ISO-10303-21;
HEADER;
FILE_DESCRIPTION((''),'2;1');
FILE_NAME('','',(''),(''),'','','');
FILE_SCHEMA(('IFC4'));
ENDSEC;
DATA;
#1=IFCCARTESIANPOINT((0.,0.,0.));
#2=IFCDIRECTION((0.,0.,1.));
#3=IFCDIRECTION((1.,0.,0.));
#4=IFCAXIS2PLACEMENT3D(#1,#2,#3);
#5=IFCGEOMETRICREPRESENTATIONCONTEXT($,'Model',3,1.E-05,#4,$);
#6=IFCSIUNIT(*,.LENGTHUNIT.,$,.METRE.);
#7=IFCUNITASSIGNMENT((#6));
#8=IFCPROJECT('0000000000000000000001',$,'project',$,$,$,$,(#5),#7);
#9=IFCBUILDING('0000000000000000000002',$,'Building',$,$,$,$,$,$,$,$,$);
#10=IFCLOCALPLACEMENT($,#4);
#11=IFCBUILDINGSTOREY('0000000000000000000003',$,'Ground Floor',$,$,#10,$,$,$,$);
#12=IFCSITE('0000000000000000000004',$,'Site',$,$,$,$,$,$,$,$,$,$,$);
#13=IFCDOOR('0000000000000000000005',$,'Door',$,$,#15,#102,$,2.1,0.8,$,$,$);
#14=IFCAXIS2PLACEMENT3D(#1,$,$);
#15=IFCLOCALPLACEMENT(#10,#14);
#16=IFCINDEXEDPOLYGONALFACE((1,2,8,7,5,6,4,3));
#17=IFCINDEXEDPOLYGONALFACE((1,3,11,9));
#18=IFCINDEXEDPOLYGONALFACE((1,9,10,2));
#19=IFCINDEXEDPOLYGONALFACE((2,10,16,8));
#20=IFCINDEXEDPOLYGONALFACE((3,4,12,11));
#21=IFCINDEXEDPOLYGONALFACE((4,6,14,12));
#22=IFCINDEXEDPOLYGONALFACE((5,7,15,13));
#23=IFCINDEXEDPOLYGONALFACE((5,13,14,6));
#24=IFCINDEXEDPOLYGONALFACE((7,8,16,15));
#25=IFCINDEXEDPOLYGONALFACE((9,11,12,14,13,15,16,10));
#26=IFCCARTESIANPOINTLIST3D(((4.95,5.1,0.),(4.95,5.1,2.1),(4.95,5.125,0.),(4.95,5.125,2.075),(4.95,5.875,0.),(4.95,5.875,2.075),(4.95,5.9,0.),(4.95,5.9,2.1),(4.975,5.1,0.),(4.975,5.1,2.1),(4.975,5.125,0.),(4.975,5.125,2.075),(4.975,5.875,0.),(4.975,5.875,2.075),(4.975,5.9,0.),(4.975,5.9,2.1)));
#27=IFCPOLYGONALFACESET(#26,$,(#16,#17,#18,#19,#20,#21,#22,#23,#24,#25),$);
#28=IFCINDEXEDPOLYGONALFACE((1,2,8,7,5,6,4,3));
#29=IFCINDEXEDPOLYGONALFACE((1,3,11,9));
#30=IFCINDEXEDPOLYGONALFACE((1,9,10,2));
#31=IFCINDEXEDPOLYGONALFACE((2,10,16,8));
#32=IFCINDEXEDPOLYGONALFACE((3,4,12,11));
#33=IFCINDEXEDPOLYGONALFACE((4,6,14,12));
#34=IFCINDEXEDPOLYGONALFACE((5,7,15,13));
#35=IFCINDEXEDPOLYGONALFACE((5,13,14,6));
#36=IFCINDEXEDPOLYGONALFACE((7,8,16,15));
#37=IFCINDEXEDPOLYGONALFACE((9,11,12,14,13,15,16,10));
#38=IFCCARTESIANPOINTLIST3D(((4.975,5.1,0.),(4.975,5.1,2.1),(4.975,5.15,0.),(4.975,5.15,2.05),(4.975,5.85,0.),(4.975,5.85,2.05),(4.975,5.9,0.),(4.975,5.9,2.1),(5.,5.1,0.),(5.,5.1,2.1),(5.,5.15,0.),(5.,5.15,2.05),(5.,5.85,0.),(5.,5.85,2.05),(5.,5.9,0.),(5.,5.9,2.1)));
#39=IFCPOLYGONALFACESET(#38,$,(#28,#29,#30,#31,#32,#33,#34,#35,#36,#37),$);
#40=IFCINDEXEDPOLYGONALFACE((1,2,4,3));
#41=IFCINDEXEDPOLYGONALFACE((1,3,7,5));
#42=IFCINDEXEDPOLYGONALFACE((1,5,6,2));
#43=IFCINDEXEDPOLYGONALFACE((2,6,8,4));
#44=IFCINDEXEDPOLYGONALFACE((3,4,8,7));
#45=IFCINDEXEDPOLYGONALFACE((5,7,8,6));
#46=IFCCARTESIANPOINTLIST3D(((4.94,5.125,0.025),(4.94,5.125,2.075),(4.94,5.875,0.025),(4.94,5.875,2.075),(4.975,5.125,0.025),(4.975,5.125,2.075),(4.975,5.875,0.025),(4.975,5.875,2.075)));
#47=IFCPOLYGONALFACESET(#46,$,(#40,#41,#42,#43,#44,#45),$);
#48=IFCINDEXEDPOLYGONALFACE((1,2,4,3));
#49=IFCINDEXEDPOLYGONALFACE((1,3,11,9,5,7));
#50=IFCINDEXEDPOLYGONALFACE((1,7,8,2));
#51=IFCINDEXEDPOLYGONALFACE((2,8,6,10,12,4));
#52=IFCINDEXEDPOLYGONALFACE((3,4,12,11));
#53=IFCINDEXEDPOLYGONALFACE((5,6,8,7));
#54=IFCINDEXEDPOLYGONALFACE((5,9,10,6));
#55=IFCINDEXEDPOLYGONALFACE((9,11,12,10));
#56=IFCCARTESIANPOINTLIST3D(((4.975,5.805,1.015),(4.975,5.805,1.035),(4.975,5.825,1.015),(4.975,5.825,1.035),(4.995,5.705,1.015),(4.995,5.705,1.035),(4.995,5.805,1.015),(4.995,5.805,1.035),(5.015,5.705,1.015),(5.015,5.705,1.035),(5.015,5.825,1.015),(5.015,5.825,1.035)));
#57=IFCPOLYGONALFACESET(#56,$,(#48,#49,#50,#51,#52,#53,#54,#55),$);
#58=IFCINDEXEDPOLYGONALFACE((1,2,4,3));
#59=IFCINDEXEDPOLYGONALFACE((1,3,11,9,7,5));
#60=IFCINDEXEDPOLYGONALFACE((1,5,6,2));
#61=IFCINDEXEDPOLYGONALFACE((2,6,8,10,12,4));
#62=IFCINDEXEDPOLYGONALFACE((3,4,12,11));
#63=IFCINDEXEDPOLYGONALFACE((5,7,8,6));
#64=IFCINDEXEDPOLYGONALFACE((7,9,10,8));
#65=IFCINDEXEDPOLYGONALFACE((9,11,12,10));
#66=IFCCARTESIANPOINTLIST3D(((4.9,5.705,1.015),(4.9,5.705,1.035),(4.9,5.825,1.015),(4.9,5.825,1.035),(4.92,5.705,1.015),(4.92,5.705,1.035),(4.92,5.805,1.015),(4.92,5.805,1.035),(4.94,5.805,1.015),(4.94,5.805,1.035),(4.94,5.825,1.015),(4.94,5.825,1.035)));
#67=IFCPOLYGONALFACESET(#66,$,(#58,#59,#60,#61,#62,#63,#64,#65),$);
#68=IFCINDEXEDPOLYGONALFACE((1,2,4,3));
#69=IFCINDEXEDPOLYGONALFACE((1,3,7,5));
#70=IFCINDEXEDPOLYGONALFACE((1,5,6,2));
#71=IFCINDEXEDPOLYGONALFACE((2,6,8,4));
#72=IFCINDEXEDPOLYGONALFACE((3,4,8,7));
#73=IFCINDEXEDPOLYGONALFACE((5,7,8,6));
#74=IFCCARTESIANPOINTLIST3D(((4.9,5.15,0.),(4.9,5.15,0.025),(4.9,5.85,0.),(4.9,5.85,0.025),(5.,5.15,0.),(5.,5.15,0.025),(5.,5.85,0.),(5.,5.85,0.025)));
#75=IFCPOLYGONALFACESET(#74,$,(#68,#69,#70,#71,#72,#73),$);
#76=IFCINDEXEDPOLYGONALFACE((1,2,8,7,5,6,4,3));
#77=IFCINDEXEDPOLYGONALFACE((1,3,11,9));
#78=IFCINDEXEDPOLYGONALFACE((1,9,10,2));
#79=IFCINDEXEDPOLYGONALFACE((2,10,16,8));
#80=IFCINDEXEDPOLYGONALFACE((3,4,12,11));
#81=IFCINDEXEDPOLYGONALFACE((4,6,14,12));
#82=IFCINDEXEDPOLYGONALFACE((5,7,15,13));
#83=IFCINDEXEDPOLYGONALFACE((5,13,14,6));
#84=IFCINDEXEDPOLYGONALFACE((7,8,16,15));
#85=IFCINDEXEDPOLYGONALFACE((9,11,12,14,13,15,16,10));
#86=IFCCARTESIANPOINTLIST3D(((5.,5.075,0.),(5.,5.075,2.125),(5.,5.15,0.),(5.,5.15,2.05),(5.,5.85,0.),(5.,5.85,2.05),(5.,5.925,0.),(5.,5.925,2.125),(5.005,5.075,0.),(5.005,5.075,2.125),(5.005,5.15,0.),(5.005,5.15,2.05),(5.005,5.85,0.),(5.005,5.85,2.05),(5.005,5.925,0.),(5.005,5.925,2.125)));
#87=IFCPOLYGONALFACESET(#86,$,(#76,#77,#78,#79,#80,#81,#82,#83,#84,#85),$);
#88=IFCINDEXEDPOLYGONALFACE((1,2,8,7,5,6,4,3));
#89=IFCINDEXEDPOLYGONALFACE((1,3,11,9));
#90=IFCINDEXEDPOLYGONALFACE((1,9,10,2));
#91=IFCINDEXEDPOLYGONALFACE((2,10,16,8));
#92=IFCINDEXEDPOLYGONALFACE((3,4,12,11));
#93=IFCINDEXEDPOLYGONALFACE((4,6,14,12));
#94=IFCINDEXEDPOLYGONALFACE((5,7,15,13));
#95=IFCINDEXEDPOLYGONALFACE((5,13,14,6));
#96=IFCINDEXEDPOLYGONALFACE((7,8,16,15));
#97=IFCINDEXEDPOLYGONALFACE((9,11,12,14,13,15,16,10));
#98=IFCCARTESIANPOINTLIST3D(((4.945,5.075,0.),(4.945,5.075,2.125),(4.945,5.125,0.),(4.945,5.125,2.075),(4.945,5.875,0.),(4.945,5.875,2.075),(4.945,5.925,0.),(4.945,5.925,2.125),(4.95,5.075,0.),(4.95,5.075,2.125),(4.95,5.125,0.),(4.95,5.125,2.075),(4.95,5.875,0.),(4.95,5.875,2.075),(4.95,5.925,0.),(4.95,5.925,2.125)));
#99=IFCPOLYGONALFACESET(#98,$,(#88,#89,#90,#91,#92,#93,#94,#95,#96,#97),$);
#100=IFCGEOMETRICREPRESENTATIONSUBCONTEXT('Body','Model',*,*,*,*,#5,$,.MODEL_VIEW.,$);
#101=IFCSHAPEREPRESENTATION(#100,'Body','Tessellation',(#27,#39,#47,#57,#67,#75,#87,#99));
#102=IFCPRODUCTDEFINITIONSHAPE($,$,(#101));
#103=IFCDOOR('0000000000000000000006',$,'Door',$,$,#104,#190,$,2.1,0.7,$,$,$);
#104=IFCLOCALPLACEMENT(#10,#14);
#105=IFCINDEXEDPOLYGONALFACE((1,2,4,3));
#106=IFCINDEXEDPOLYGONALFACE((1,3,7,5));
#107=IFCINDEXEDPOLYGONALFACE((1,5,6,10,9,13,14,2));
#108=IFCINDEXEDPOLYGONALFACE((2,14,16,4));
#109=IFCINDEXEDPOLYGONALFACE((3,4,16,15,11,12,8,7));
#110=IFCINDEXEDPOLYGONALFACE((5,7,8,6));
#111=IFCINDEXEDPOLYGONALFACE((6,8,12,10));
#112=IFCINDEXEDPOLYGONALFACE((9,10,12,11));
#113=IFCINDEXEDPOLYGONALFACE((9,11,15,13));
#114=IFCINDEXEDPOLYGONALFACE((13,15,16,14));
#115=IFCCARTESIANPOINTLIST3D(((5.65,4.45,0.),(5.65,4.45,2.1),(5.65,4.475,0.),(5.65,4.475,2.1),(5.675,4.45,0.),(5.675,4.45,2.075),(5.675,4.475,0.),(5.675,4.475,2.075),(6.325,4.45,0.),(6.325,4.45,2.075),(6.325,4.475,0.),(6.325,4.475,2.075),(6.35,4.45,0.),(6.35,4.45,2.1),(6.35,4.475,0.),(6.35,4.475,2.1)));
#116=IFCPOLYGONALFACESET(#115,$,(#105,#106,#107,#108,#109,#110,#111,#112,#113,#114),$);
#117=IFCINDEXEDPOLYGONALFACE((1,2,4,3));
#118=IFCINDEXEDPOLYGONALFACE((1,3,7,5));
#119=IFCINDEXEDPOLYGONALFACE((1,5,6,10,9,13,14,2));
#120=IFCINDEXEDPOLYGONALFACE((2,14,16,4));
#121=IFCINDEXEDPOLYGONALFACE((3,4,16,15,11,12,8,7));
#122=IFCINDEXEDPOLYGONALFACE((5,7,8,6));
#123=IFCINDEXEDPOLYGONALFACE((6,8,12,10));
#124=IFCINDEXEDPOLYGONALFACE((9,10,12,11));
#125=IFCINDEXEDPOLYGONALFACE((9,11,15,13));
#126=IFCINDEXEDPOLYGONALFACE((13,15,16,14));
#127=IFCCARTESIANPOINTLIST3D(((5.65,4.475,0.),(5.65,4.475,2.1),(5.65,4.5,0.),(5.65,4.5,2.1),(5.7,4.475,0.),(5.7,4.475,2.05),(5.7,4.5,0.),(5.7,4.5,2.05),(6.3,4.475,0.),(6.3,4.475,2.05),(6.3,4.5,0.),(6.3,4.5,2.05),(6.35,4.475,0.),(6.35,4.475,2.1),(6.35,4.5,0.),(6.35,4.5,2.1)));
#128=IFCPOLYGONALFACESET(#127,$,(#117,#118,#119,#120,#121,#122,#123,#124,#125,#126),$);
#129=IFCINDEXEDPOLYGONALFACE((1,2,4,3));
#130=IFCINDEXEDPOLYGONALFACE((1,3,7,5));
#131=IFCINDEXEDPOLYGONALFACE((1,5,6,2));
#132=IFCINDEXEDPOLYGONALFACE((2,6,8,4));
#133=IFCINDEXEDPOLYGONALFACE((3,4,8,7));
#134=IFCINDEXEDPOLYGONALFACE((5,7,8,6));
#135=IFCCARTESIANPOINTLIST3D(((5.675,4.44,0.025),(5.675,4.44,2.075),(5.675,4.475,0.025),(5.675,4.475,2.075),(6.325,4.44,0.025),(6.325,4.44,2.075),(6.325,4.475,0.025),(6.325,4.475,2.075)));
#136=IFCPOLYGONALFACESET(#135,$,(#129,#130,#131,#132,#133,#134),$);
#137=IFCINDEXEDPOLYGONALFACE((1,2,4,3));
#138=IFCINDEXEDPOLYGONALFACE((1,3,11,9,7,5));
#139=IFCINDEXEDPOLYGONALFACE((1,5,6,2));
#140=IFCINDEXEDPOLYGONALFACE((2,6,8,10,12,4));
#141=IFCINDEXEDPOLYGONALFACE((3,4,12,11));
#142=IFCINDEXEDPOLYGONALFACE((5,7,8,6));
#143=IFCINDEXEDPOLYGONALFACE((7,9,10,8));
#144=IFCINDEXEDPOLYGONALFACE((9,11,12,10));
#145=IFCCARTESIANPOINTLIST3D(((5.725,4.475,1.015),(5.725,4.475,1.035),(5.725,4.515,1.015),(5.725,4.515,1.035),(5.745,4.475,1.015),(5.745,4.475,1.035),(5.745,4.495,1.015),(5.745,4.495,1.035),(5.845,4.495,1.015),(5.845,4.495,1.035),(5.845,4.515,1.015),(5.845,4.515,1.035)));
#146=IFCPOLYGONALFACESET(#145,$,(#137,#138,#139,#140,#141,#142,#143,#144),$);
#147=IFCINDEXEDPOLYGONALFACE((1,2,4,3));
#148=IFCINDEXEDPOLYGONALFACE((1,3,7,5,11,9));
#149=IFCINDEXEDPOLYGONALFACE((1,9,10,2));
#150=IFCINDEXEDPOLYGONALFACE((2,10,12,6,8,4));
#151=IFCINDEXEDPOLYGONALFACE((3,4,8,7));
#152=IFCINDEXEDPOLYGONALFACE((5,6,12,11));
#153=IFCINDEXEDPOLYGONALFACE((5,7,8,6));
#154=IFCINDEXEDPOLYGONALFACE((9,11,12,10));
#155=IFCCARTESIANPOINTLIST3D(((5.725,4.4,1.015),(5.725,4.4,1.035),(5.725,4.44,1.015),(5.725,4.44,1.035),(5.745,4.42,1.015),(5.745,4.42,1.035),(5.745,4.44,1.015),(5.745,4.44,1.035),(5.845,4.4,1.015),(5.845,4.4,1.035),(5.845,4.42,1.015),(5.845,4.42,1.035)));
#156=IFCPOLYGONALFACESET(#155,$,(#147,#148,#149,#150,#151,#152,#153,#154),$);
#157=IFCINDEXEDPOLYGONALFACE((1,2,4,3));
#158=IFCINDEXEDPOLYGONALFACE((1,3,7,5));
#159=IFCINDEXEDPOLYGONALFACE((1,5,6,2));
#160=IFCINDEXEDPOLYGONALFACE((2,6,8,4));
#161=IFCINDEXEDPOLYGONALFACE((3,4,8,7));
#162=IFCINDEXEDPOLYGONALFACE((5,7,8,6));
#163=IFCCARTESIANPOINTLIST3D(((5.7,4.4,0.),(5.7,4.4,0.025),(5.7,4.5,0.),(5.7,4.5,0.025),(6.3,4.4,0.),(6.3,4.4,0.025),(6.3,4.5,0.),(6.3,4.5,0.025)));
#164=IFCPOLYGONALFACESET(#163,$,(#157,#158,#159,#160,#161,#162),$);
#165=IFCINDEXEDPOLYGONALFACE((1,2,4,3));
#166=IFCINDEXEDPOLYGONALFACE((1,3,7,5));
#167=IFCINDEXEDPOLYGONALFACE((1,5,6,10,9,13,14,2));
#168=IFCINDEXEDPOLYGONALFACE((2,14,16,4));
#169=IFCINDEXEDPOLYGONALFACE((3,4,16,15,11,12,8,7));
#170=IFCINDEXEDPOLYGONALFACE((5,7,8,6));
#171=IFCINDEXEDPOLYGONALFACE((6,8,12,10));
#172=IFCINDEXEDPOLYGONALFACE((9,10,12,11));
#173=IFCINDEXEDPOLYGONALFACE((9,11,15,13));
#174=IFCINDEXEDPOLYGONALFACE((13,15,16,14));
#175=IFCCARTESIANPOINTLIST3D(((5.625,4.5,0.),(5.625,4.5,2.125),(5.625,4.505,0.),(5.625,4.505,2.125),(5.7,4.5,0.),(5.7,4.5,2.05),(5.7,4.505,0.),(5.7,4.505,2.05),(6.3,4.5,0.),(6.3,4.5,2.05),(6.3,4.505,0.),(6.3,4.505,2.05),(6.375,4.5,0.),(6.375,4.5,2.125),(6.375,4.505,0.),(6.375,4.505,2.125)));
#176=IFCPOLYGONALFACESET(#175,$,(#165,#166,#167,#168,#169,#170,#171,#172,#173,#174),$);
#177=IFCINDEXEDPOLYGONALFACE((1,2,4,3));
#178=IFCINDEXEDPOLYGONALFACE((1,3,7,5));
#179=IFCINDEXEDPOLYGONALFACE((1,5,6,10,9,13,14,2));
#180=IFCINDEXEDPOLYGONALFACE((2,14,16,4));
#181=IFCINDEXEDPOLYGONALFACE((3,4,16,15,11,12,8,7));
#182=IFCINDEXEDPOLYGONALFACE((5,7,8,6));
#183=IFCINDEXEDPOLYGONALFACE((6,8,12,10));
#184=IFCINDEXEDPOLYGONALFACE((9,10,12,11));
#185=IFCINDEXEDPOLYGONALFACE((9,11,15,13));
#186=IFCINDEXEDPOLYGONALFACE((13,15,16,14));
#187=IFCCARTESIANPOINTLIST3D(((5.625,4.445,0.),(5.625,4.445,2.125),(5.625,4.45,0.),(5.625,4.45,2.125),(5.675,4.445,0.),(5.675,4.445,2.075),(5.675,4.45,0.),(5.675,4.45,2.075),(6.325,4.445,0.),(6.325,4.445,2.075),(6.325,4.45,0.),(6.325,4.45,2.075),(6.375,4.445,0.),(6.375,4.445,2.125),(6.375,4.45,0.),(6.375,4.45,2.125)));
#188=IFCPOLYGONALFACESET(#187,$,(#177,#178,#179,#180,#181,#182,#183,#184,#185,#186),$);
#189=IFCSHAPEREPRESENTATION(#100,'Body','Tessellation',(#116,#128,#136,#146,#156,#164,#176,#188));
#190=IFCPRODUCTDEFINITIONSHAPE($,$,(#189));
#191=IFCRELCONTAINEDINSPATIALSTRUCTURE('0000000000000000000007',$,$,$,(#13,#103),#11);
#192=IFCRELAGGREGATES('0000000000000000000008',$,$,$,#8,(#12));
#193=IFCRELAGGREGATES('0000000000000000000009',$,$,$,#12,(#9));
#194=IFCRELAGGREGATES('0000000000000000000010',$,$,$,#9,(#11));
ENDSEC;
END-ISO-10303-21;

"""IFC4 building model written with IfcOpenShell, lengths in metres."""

from ifc_helpers import new_model, si_unit, frame, origin_with_axes, place, context, subcontext, project, spatial, line, indexed_curve, outline, extrude, element, save


model = new_model("IFC4")

# Units and contexts
model_context = context("Model", 3, precision=1e-05, world=origin_with_axes())
body_context = subcontext(model_context, "Body", "Model", "MODEL_VIEW")
ifc_project = project(units=[si_unit("LENGTHUNIT", "METRE")], contexts=[model_context])

# Site, building, storey
site = spatial("IfcSite", under=ifc_project, Name="Site")
building = spatial("IfcBuilding", under=site, Name="Building")
storey_placement = place(None, origin_with_axes())
storey = spatial("IfcBuildingStorey", under=building, at=storey_placement, Name="Ground Floor")

# Doors
door_1_placement = place(storey_placement, frame((5.0, 5.1, 0.0), z_axis=(0.0, 0.0, 1.0), x_axis=(0.0, 1.0, 0.0)))
element("IfcDoor", 1, at=door_1_placement, inside=storey, Name="Door", OverallHeight=2.1, OverallWidth=0.8, context=body_context, shape_type="SweptSolid", body=[
    extrude(outline(indexed_curve([(0.0, 0.0), (0.0, 2.1), (0.8, 2.1), (0.8, 0.0), (0.775, 0.0), (0.775, 2.075), (0.025, 2.075), (0.025, 0.0)], segments=[line(1, 2, 3, 4, 5, 6, 7, 8, 1)])), frame((0.0, 0.025, 0.0), z_axis=(0.0, -1.0, 0.0), x_axis=(1.0, 0.0, 0.0)), (0.0, 0.0, -1.0), 0.025),
    extrude(outline(indexed_curve([(0.0, 0.0), (0.0, 2.1), (0.8, 2.1), (0.8, 0.0), (0.75, 0.0), (0.75, 2.05), (0.05, 2.05), (0.05, 0.0)], segments=[line(1, 2, 3, 4, 5, 6, 7, 8, 1)])), frame((0.0, 0.0, 0.0), z_axis=(0.0, -1.0, 0.0), x_axis=(1.0, 0.0, 0.0)), (0.0, 0.0, -1.0), 0.025),
    extrude(outline(indexed_curve([(0.0, 0.0), (0.75, 0.0), (0.75, 0.035), (0.0, 0.035)], segments=[line(1, 2, 3, 4, 1)])), frame((0.025, 0.025, 0.025), z_axis=(0.0, 0.0, 1.0), x_axis=(1.0, 0.0, 0.0)), (0.0, 0.0, 1.0), 2.05),
    extrude(outline(indexed_curve([(0.0, 0.0), (0.0, -0.04), (-0.12, -0.04), (-0.12, -0.02), (-0.02, -0.02), (-0.02, 0.0)], segments=[line(1, 2, 3, 4, 5, 6, 1)])), frame((0.725, 0.025, 1.015), z_axis=(0.0, 0.0, 1.0), x_axis=(1.0, 0.0, 0.0)), (0.0, 0.0, 1.0), 0.02),
    extrude(outline(indexed_curve([(0.0, 0.0), (0.0, 0.04), (-0.12, 0.04), (-0.12, 0.02), (-0.02, 0.02), (-0.02, 0.0)], segments=[line(1, 2, 3, 4, 5, 6, 1)])), frame((0.725, 0.06, 1.015), z_axis=(0.0, 0.0, 1.0), x_axis=(1.0, 0.0, 0.0)), (0.0, 0.0, 1.0), 0.02),
    extrude(outline(indexed_curve([(0.0, 0.0), (0.7, 0.0), (0.7, 0.1), (0.0, 0.1)], segments=[line(1, 2, 3, 4, 1)])), frame((0.05, 0.0, 0.0), z_axis=(0.0, 0.0, 1.0), x_axis=(1.0, 0.0, 0.0)), (0.0, 0.0, 1.0), 0.025),
    extrude(outline(indexed_curve([(0.0, 0.0), (0.0, 2.125), (0.85, 2.125), (0.85, 0.0), (0.775, 0.0), (0.775, 2.05), (0.075, 2.05), (0.075, 0.0)], segments=[line(1, 2, 3, 4, 5, 6, 7, 8, 1)])), frame((-0.025, -0.005, 0.0), z_axis=(0.0, -1.0, 0.0), x_axis=(1.0, 0.0, 0.0)), (0.0, 0.0, -1.0), 0.005),
    extrude(outline(indexed_curve([(0.0, 0.0), (0.0, 2.125), (0.85, 2.125), (0.85, 0.0), (0.8, 0.0), (0.8, 2.075), (0.05, 2.075), (0.05, 0.0)], segments=[line(1, 2, 3, 4, 5, 6, 7, 8, 1)])), frame((-0.025, 0.05, 0.0), z_axis=(0.0, -1.0, 0.0), x_axis=(1.0, 0.0, 0.0)), (0.0, 0.0, -1.0), 0.005),
])
door_2_placement = place(storey_placement, frame((6.35, 4.5, 0.0), z_axis=(0.0, 0.0, 1.0), x_axis=(-1.0, 0.0, 0.0)))
element("IfcDoor", 2, at=door_2_placement, inside=storey, Name="Door", OverallHeight=2.1, OverallWidth=0.7, context=body_context, shape_type="SweptSolid", body=[
    extrude(outline(indexed_curve([(0.0, 0.0), (0.0, 2.1), (0.7, 2.1), (0.7, 0.0), (0.675, 0.0), (0.675, 2.075), (0.025, 2.075), (0.025, 0.0)], segments=[line(1, 2, 3, 4, 5, 6, 7, 8, 1)])), frame((0.0, 0.025, 0.0), z_axis=(0.0, -1.0, 0.0), x_axis=(1.0, 0.0, 0.0)), (0.0, 0.0, -1.0), 0.025),
    extrude(outline(indexed_curve([(0.0, 0.0), (0.0, 2.1), (0.7, 2.1), (0.7, 0.0), (0.65, 0.0), (0.65, 2.05), (0.05, 2.05), (0.05, 0.0)], segments=[line(1, 2, 3, 4, 5, 6, 7, 8, 1)])), frame((0.0, 0.0, 0.0), z_axis=(0.0, -1.0, 0.0), x_axis=(1.0, 0.0, 0.0)), (0.0, 0.0, -1.0), 0.025),
    extrude(outline(indexed_curve([(0.0, 0.0), (0.65, 0.0), (0.65, 0.035), (0.0, 0.035)], segments=[line(1, 2, 3, 4, 1)])), frame((0.025, 0.025, 0.025), z_axis=(0.0, 0.0, 1.0), x_axis=(1.0, 0.0, 0.0)), (0.0, 0.0, 1.0), 2.05),
    extrude(outline(indexed_curve([(0.0, 0.0), (0.0, -0.04), (-0.12, -0.04), (-0.12, -0.02), (-0.02, -0.02), (-0.02, 0.0)], segments=[line(1, 2, 3, 4, 5, 6, 1)])), frame((0.625, 0.025, 1.015), z_axis=(0.0, 0.0, 1.0), x_axis=(1.0, 0.0, 0.0)), (0.0, 0.0, 1.0), 0.02),
    extrude(outline(indexed_curve([(0.0, 0.0), (0.0, 0.04), (-0.12, 0.04), (-0.12, 0.02), (-0.02, 0.02), (-0.02, 0.0)], segments=[line(1, 2, 3, 4, 5, 6, 1)])), frame((0.625, 0.06, 1.015), z_axis=(0.0, 0.0, 1.0), x_axis=(1.0, 0.0, 0.0)), (0.0, 0.0, 1.0), 0.02),
    extrude(outline(indexed_curve([(0.0, 0.0), (0.6, 0.0), (0.6, 0.1), (0.0, 0.1)], segments=[line(1, 2, 3, 4, 1)])), frame((0.05, 0.0, 0.0), z_axis=(0.0, 0.0, 1.0), x_axis=(1.0, 0.0, 0.0)), (0.0, 0.0, 1.0), 0.025),
    extrude(outline(indexed_curve([(0.0, 0.0), (0.0, 2.125), (0.75, 2.125), (0.75, 0.0), (0.675, 0.0), (0.675, 2.05), (0.075, 2.05), (0.075, 0.0)], segments=[line(1, 2, 3, 4, 5, 6, 7, 8, 1)])), frame((-0.025, -0.005, 0.0), z_axis=(0.0, -1.0, 0.0), x_axis=(1.0, 0.0, 0.0)), (0.0, 0.0, -1.0), 0.005),
    extrude(outline(indexed_curve([(0.0, 0.0), (0.0, 2.125), (0.75, 2.125), (0.75, 0.0), (0.7, 0.0), (0.7, 2.075), (0.05, 2.075), (0.05, 0.0)], segments=[line(1, 2, 3, 4, 5, 6, 7, 8, 1)])), frame((-0.025, 0.05, 0.0), z_axis=(0.0, -1.0, 0.0), x_axis=(1.0, 0.0, 0.0)), (0.0, 0.0, -1.0), 0.005),
])

save(model, "model.ifc")
